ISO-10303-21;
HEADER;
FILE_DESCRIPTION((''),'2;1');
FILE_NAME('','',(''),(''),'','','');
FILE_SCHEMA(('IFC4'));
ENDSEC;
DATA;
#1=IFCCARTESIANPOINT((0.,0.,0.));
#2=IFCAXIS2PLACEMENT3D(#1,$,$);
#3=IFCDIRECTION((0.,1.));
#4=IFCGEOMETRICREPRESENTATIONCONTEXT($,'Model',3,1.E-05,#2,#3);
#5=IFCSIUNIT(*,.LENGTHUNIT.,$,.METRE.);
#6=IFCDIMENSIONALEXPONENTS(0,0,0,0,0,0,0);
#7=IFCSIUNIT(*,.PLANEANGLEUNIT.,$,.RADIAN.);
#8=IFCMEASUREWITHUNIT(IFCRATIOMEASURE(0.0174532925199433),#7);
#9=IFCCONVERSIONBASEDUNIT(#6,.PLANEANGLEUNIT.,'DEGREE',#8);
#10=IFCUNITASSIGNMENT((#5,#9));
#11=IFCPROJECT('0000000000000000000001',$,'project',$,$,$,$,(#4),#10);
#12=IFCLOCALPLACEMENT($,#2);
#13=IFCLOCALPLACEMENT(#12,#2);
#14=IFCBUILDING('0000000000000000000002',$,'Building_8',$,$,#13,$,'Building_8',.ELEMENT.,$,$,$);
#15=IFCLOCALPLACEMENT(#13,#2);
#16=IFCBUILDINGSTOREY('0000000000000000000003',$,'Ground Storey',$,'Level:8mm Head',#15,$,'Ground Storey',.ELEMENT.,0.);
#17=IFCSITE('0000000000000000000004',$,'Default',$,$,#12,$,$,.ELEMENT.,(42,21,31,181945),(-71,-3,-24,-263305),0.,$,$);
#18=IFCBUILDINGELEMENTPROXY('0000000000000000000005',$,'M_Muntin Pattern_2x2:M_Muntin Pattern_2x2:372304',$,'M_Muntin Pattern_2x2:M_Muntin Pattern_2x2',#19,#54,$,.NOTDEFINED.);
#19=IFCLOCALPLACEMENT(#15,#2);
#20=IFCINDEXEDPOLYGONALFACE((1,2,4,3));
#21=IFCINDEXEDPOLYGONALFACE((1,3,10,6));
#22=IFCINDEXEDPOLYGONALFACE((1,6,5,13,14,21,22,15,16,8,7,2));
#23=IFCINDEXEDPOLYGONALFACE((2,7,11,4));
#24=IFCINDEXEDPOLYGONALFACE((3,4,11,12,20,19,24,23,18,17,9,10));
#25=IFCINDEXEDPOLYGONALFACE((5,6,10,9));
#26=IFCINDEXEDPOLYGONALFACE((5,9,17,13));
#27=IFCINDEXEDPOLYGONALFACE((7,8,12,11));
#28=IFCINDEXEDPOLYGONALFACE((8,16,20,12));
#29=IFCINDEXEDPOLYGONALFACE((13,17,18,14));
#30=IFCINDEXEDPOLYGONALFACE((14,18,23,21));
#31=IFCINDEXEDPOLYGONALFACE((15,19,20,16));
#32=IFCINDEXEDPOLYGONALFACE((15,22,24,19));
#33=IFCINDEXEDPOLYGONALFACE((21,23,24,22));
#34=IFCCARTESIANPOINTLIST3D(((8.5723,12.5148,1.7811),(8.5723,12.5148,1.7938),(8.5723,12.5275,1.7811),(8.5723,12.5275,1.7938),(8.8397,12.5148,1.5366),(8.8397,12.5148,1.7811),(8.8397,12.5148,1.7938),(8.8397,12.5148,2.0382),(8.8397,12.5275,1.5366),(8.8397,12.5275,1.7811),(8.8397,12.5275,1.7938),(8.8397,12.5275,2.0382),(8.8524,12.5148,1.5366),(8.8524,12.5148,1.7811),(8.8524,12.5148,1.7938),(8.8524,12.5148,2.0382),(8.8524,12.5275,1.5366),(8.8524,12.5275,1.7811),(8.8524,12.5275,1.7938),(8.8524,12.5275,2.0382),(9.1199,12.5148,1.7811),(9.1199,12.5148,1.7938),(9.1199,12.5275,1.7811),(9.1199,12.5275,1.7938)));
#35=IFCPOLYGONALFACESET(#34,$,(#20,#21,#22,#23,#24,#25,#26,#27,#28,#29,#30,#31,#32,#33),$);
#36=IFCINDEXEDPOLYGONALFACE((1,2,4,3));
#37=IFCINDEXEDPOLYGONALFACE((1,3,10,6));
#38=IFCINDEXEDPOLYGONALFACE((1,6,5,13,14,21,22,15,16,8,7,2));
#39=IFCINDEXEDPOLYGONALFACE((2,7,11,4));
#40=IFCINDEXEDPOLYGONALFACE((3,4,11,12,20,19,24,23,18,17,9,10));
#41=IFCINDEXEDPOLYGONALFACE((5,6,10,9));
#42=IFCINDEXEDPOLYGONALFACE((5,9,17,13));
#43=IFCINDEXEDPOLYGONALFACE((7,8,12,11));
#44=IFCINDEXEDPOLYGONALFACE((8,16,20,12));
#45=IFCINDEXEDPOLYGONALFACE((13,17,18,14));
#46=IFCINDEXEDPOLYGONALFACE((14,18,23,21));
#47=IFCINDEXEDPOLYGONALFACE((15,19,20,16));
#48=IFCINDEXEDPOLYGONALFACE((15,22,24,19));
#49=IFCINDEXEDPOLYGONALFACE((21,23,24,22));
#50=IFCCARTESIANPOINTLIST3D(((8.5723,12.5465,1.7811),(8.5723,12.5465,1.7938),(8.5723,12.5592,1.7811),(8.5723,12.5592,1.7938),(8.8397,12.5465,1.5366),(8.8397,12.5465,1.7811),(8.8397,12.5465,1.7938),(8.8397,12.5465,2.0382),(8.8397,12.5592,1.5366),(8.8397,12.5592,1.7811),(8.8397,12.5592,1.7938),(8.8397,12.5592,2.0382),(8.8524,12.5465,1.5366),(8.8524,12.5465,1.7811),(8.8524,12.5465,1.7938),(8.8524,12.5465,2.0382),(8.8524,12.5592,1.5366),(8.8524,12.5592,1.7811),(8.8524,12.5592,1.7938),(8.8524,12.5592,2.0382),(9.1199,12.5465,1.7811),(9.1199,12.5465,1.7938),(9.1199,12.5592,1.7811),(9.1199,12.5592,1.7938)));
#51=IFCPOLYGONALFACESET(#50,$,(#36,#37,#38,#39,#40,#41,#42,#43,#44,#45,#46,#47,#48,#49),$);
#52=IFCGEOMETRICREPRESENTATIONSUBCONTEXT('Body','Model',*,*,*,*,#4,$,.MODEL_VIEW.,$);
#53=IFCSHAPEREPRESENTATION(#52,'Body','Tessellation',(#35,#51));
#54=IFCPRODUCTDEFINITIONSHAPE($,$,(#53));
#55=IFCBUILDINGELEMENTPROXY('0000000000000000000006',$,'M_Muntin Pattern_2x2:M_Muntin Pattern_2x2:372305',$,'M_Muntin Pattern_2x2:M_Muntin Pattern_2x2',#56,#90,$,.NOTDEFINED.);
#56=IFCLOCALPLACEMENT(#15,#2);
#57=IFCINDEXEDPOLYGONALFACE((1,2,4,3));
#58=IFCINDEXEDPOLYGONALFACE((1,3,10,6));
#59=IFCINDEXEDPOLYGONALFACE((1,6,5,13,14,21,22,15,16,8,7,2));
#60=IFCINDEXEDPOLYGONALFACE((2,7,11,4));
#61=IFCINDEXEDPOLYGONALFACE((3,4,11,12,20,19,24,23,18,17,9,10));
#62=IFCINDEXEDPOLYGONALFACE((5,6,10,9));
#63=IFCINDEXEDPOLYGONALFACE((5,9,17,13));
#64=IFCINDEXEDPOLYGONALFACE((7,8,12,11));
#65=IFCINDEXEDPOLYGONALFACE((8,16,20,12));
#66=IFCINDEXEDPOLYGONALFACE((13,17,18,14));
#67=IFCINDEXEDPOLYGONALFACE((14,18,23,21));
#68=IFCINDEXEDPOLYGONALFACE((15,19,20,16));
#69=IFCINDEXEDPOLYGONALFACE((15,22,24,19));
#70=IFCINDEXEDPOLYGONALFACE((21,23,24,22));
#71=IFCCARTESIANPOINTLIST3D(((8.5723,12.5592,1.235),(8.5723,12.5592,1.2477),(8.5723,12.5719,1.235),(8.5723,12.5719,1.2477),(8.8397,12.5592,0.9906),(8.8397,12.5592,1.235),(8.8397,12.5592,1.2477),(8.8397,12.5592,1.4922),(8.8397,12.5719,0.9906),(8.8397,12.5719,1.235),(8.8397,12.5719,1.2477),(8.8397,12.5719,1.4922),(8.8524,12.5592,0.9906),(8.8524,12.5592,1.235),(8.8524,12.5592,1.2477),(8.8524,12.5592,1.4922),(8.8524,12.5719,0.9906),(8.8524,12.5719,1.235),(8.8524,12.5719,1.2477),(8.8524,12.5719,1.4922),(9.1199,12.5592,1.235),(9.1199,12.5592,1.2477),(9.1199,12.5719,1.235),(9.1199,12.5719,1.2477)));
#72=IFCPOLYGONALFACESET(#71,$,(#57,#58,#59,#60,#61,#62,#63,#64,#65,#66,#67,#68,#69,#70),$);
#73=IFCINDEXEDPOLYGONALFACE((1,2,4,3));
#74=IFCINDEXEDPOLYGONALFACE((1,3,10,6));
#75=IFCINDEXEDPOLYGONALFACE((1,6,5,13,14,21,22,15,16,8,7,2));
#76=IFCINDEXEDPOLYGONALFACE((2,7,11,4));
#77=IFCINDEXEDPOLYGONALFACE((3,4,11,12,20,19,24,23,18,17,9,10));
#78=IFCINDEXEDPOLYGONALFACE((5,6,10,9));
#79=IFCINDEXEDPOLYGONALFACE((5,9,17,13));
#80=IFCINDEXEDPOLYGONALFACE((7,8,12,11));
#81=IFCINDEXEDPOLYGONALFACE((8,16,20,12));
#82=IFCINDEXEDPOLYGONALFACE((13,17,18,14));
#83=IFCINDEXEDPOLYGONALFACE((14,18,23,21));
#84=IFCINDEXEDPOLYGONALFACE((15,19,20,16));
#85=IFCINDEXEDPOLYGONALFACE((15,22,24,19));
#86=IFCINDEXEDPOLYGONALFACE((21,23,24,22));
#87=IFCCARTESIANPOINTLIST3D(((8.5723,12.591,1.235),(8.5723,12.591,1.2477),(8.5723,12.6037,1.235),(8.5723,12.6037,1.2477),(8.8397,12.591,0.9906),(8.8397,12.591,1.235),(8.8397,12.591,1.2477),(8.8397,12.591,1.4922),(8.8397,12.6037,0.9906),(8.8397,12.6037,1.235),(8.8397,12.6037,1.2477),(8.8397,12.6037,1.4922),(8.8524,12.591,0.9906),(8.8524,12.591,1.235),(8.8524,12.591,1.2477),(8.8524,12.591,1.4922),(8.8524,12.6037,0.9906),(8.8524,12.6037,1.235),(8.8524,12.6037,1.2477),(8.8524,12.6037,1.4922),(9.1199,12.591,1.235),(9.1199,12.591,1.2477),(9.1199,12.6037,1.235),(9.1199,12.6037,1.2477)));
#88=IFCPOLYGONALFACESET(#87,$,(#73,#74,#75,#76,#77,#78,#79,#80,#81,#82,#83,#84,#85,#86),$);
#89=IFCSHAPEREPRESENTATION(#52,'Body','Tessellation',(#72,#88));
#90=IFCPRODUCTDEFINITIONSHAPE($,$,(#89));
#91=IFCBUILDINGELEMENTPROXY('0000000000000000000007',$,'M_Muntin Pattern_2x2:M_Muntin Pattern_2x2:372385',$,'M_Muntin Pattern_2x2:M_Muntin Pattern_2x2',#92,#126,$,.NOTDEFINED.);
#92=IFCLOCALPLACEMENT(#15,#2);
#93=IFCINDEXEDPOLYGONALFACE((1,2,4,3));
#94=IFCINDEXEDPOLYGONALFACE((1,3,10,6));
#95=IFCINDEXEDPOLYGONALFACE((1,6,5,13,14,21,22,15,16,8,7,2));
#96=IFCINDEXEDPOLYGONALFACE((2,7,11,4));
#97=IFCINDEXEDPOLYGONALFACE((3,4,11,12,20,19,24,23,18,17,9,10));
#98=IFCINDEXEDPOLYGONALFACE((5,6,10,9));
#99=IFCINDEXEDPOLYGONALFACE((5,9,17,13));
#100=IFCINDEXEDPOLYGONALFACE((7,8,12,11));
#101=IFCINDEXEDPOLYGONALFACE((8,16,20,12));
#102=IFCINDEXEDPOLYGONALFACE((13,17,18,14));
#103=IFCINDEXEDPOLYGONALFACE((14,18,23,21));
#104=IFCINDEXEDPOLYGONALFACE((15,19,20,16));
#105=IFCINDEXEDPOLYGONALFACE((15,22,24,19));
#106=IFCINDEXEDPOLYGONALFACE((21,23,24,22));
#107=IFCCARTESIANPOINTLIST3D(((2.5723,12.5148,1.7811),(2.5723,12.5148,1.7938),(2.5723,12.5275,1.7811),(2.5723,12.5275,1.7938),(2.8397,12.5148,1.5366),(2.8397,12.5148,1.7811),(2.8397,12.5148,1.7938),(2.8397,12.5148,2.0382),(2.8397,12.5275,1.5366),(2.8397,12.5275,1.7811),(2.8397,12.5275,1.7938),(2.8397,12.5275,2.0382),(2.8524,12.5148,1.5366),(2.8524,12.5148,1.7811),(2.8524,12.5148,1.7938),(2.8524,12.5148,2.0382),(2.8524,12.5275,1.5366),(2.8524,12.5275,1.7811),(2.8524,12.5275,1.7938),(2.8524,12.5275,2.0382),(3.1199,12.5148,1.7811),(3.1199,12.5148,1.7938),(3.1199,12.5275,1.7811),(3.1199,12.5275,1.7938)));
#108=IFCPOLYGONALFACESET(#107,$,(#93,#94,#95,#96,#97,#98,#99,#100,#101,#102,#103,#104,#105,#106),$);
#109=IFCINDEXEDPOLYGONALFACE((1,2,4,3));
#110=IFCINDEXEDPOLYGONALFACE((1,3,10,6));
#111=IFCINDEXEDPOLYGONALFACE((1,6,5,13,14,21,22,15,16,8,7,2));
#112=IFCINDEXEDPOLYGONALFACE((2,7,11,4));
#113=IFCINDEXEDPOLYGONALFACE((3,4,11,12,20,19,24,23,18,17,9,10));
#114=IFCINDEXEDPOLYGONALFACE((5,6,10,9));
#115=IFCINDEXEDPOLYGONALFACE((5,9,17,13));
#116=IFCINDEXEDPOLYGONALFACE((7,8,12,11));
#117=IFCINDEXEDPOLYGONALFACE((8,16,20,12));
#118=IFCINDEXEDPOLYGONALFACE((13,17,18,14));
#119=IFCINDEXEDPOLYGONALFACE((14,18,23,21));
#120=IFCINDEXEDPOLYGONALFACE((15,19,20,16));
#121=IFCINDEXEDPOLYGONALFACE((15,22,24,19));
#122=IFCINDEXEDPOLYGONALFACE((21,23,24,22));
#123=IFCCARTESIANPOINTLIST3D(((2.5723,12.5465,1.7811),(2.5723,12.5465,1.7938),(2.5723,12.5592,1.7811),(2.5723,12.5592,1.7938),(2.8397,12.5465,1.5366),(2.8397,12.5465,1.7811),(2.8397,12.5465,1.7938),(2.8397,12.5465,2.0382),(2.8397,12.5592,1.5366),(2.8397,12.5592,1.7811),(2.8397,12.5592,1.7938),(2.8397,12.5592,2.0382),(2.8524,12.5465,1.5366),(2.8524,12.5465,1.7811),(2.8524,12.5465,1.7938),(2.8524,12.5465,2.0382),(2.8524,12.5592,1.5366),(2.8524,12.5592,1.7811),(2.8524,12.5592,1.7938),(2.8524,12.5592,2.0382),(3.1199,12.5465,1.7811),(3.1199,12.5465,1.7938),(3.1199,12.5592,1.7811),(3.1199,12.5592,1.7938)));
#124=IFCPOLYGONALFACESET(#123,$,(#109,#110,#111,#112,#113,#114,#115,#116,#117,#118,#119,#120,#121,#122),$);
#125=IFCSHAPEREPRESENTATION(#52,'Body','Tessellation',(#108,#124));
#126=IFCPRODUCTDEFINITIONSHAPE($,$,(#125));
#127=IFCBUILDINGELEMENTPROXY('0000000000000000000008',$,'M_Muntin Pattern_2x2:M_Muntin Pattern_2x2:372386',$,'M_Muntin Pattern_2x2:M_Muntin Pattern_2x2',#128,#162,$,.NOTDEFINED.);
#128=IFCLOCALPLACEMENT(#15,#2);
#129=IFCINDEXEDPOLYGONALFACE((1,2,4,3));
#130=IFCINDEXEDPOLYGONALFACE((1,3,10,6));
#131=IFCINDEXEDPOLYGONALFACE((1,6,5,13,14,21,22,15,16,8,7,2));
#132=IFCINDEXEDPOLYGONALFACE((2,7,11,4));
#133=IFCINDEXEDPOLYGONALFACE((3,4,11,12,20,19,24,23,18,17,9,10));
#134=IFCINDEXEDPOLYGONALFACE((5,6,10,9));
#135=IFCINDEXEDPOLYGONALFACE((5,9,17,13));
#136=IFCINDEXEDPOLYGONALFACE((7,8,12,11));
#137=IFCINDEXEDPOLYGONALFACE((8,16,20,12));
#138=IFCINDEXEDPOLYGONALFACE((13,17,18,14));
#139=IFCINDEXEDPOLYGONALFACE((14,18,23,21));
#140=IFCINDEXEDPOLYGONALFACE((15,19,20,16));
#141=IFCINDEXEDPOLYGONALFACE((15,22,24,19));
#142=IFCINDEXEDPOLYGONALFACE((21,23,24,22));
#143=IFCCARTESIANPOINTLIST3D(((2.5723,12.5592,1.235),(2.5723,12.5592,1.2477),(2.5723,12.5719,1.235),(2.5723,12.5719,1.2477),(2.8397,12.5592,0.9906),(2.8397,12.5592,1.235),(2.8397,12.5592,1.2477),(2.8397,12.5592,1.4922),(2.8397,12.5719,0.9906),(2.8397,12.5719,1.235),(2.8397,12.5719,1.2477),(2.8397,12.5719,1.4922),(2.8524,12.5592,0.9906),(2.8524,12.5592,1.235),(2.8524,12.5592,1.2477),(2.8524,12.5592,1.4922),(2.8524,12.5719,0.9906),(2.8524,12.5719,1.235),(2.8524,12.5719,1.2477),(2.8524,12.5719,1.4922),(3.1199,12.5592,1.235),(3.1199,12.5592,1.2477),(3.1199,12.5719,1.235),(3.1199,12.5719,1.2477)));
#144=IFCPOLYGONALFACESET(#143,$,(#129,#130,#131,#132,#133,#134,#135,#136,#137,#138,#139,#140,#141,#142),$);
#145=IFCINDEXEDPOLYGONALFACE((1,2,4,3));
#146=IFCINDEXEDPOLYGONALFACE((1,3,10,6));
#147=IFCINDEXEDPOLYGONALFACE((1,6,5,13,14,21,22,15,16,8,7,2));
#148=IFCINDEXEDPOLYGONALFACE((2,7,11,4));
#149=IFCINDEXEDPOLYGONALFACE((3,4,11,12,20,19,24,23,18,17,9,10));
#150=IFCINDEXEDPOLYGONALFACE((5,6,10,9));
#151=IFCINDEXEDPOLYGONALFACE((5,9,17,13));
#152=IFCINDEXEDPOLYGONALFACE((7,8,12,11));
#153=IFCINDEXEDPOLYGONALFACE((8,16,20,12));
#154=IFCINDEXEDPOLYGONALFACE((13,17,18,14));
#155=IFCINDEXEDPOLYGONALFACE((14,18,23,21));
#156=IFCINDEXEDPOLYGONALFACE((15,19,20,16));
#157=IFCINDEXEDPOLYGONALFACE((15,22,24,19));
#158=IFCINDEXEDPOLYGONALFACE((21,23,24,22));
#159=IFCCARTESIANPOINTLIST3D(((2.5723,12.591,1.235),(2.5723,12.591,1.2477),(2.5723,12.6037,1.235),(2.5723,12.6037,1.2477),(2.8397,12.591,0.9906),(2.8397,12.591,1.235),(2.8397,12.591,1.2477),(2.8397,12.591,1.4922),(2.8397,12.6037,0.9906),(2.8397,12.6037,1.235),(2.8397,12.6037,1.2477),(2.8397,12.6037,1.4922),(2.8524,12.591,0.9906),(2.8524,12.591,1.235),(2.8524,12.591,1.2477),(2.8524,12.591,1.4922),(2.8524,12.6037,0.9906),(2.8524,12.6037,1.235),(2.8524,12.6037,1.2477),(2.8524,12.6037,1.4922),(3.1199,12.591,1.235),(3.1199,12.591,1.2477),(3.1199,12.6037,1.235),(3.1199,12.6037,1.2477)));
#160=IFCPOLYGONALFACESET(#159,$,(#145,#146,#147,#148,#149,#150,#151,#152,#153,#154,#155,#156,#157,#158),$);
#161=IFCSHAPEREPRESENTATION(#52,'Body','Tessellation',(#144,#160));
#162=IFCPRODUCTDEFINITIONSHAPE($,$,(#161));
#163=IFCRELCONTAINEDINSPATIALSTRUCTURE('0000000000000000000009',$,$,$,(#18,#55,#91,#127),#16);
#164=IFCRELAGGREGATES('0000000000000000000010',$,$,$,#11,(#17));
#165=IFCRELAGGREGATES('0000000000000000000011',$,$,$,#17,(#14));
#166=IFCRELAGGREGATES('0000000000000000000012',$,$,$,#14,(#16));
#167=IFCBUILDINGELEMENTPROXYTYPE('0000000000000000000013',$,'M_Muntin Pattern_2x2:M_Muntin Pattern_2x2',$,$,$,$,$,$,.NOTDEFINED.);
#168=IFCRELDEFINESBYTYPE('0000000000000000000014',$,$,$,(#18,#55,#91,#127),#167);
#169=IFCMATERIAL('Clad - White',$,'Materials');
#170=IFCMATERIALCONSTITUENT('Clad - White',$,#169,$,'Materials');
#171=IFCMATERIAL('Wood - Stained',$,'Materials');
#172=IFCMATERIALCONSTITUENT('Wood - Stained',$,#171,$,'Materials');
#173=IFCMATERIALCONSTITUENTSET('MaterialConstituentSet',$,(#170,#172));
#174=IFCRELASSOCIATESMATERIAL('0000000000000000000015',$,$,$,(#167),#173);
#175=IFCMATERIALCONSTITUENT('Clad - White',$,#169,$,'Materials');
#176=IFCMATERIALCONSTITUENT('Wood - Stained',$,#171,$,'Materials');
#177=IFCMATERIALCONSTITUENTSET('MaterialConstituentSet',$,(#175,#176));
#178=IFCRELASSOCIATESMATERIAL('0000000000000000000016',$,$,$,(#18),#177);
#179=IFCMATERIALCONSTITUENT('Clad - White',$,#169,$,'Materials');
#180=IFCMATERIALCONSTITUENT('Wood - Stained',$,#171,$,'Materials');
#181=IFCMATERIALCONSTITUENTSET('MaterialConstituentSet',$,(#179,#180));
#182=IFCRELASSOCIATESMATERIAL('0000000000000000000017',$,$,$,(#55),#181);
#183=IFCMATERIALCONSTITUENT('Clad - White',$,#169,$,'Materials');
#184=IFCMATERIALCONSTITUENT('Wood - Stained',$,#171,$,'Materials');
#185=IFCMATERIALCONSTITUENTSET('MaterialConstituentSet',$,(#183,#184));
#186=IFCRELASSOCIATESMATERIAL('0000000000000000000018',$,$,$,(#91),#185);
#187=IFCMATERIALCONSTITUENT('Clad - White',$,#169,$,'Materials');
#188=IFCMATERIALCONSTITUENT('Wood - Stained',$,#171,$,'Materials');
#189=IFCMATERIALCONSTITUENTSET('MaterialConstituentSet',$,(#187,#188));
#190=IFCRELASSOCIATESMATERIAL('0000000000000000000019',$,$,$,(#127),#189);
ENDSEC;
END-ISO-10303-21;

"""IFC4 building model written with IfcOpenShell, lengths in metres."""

from ifc_helpers import new_model, entity, si_unit, converted_unit, direction, frame, origin, place, context, subcontext, project, spatial, indexed_curve, outline, extrude, source, transform, mapped, material, constituent, constituent_set, type_object, type_shapes, element, save


model = new_model("IFC4")

# Units and contexts
model_context = context("Model", 3, precision=1e-05, world=origin(), true_north=direction((0.0, 1.0)))
body_context = subcontext(model_context, "Body", "Model", "MODEL_VIEW")
ifc_project = project(units=[si_unit("LENGTHUNIT", "METRE"), converted_unit("PLANEANGLEUNIT", "DEGREE", entity("IfcRatioMeasure", 0.0174532925199433), si_unit("PLANEANGLEUNIT", "RADIAN"), dimensions=[0, 0, 0, 0, 0, 0, 0])], contexts=[model_context])

# Site, building, storey
site_placement = place(None, origin())
site = spatial("IfcSite", under=ifc_project, at=site_placement, Name="Default", CompositionType="ELEMENT", RefLatitude=(42, 21, 31, 181945), RefLongitude=(-71, -3, -24, -263305), RefElevation=0.0)
building_placement = place(site_placement, origin())
building = spatial("IfcBuilding", under=site, at=building_placement, Name="Building_8", LongName="Building_8", CompositionType="ELEMENT")
storey_placement = place(building_placement, origin())
storey = spatial("IfcBuildingStorey", under=building, at=storey_placement, Name="Ground Storey", ObjectType="Level:8mm Head", LongName="Ground Storey", CompositionType="ELEMENT", Elevation=0.0)

# Building element proxies
ifc_material_1 = material(Name="Clad - White", Category="Materials")
ifc_material_2 = material(Name="Wood - Stained", Category="Materials")
ifc_constituent_1 = constituent(ifc_material_1, Name="Clad - White", Category="Materials")
ifc_constituent_2 = constituent(ifc_material_2, Name="Wood - Stained", Category="Materials")
ifc_constituent_set_1 = constituent_set(constituents=[ifc_constituent_1, ifc_constituent_2], Name="MaterialConstituentSet")
building_element_proxy_type_1 = type_object("IfcBuildingElementProxyType", Name="M_Muntin Pattern_2x2:M_Muntin Pattern_2x2", PredefinedType="NOTDEFINED", material=ifc_constituent_set_1)
shared_shape_1 = source(origin(), body_context, "Body", "SweptSolid", [
    extrude(outline(indexed_curve([(0.0064, -0.0064), (0.2508, -0.0064), (0.2508, 0.0063), (0.0064, 0.0063), (0.0064, 0.2738), (-0.0063, 0.2738), (-0.0063, 0.0063), (-0.2508, 0.0063), (-0.2508, -0.0064), (-0.0063, -0.0064), (-0.0063, -0.2738), (0.0064, -0.2738), (0.0064, -0.0064)], self_intersect=False)), frame((0.0, -0.0222, 0.2508), z_axis=(0.0, 1.0, 0.0), x_axis=(0.0, 0.0, 1.0)), (0.0, 0.0, 1.0), 0.0127),
    extrude(outline(indexed_curve([(0.0064, -0.0064), (0.2508, -0.0064), (0.2508, 0.0063), (0.0064, 0.0063), (0.0064, 0.2738), (-0.0063, 0.2738), (-0.0063, 0.0063), (-0.2508, 0.0063), (-0.2508, -0.0064), (-0.0063, -0.0064), (-0.0063, -0.2738), (0.0064, -0.2738), (0.0064, -0.0064)], self_intersect=False)), frame((0.0, 0.0095, 0.2508), z_axis=(0.0, 1.0, 0.0), x_axis=(0.0, 0.0, 1.0)), (0.0, 0.0, 1.0), 0.0127),
])
type_shapes(building_element_proxy_type_1, [shared_shape_1])
ifc_constituent_3 = constituent(ifc_material_1, Name="Clad - White", Category="Materials")
ifc_constituent_4 = constituent(ifc_material_2, Name="Wood - Stained", Category="Materials")
ifc_constituent_set_2 = constituent_set(constituents=[ifc_constituent_3, ifc_constituent_4], Name="MaterialConstituentSet")
proxy_1_placement = place(storey_placement, frame((8.8461, 12.537, 1.5366)))
element("IfcBuildingElementProxy", 1, at=proxy_1_placement, inside=storey, type_object=building_element_proxy_type_1, material=ifc_constituent_set_2, Name="M_Muntin Pattern_2x2:M_Muntin Pattern_2x2:372304", ObjectType="M_Muntin Pattern_2x2:M_Muntin Pattern_2x2", PredefinedType="NOTDEFINED", context=body_context, shape_type="MappedRepresentation", body=[
    mapped(shared_shape_1, transform((0.0, 0.0, 0.0), scale=1.0)),
])
ifc_constituent_5 = constituent(ifc_material_1, Name="Clad - White", Category="Materials")
ifc_constituent_6 = constituent(ifc_material_2, Name="Wood - Stained", Category="Materials")
ifc_constituent_set_3 = constituent_set(constituents=[ifc_constituent_5, ifc_constituent_6], Name="MaterialConstituentSet")
proxy_2_placement = place(storey_placement, frame((8.8461, 12.5814, 0.9906)))
element("IfcBuildingElementProxy", 2, at=proxy_2_placement, inside=storey, type_object=building_element_proxy_type_1, material=ifc_constituent_set_3, Name="M_Muntin Pattern_2x2:M_Muntin Pattern_2x2:372305", ObjectType="M_Muntin Pattern_2x2:M_Muntin Pattern_2x2", PredefinedType="NOTDEFINED", context=body_context, shape_type="MappedRepresentation", body=[
    mapped(shared_shape_1, transform((0.0, 0.0, 0.0), scale=1.0)),
])
ifc_constituent_7 = constituent(ifc_material_1, Name="Clad - White", Category="Materials")
ifc_constituent_8 = constituent(ifc_material_2, Name="Wood - Stained", Category="Materials")
ifc_constituent_set_4 = constituent_set(constituents=[ifc_constituent_7, ifc_constituent_8], Name="MaterialConstituentSet")
proxy_3_placement = place(storey_placement, frame((2.8461, 12.537, 1.5366)))
element("IfcBuildingElementProxy", 3, at=proxy_3_placement, inside=storey, type_object=building_element_proxy_type_1, material=ifc_constituent_set_4, Name="M_Muntin Pattern_2x2:M_Muntin Pattern_2x2:372385", ObjectType="M_Muntin Pattern_2x2:M_Muntin Pattern_2x2", PredefinedType="NOTDEFINED", context=body_context, shape_type="MappedRepresentation", body=[
    mapped(shared_shape_1, transform((0.0, 0.0, 0.0), scale=1.0)),
])
ifc_constituent_9 = constituent(ifc_material_1, Name="Clad - White", Category="Materials")
ifc_constituent_10 = constituent(ifc_material_2, Name="Wood - Stained", Category="Materials")
ifc_constituent_set_5 = constituent_set(constituents=[ifc_constituent_9, ifc_constituent_10], Name="MaterialConstituentSet")
proxy_4_placement = place(storey_placement, frame((2.8461, 12.5814, 0.9906)))
element("IfcBuildingElementProxy", 4, at=proxy_4_placement, inside=storey, type_object=building_element_proxy_type_1, material=ifc_constituent_set_5, Name="M_Muntin Pattern_2x2:M_Muntin Pattern_2x2:372386", ObjectType="M_Muntin Pattern_2x2:M_Muntin Pattern_2x2", PredefinedType="NOTDEFINED", context=body_context, shape_type="MappedRepresentation", body=[
    mapped(shared_shape_1, transform((0.0, 0.0, 0.0), scale=1.0)),
])

save(model, "model.ifc")
